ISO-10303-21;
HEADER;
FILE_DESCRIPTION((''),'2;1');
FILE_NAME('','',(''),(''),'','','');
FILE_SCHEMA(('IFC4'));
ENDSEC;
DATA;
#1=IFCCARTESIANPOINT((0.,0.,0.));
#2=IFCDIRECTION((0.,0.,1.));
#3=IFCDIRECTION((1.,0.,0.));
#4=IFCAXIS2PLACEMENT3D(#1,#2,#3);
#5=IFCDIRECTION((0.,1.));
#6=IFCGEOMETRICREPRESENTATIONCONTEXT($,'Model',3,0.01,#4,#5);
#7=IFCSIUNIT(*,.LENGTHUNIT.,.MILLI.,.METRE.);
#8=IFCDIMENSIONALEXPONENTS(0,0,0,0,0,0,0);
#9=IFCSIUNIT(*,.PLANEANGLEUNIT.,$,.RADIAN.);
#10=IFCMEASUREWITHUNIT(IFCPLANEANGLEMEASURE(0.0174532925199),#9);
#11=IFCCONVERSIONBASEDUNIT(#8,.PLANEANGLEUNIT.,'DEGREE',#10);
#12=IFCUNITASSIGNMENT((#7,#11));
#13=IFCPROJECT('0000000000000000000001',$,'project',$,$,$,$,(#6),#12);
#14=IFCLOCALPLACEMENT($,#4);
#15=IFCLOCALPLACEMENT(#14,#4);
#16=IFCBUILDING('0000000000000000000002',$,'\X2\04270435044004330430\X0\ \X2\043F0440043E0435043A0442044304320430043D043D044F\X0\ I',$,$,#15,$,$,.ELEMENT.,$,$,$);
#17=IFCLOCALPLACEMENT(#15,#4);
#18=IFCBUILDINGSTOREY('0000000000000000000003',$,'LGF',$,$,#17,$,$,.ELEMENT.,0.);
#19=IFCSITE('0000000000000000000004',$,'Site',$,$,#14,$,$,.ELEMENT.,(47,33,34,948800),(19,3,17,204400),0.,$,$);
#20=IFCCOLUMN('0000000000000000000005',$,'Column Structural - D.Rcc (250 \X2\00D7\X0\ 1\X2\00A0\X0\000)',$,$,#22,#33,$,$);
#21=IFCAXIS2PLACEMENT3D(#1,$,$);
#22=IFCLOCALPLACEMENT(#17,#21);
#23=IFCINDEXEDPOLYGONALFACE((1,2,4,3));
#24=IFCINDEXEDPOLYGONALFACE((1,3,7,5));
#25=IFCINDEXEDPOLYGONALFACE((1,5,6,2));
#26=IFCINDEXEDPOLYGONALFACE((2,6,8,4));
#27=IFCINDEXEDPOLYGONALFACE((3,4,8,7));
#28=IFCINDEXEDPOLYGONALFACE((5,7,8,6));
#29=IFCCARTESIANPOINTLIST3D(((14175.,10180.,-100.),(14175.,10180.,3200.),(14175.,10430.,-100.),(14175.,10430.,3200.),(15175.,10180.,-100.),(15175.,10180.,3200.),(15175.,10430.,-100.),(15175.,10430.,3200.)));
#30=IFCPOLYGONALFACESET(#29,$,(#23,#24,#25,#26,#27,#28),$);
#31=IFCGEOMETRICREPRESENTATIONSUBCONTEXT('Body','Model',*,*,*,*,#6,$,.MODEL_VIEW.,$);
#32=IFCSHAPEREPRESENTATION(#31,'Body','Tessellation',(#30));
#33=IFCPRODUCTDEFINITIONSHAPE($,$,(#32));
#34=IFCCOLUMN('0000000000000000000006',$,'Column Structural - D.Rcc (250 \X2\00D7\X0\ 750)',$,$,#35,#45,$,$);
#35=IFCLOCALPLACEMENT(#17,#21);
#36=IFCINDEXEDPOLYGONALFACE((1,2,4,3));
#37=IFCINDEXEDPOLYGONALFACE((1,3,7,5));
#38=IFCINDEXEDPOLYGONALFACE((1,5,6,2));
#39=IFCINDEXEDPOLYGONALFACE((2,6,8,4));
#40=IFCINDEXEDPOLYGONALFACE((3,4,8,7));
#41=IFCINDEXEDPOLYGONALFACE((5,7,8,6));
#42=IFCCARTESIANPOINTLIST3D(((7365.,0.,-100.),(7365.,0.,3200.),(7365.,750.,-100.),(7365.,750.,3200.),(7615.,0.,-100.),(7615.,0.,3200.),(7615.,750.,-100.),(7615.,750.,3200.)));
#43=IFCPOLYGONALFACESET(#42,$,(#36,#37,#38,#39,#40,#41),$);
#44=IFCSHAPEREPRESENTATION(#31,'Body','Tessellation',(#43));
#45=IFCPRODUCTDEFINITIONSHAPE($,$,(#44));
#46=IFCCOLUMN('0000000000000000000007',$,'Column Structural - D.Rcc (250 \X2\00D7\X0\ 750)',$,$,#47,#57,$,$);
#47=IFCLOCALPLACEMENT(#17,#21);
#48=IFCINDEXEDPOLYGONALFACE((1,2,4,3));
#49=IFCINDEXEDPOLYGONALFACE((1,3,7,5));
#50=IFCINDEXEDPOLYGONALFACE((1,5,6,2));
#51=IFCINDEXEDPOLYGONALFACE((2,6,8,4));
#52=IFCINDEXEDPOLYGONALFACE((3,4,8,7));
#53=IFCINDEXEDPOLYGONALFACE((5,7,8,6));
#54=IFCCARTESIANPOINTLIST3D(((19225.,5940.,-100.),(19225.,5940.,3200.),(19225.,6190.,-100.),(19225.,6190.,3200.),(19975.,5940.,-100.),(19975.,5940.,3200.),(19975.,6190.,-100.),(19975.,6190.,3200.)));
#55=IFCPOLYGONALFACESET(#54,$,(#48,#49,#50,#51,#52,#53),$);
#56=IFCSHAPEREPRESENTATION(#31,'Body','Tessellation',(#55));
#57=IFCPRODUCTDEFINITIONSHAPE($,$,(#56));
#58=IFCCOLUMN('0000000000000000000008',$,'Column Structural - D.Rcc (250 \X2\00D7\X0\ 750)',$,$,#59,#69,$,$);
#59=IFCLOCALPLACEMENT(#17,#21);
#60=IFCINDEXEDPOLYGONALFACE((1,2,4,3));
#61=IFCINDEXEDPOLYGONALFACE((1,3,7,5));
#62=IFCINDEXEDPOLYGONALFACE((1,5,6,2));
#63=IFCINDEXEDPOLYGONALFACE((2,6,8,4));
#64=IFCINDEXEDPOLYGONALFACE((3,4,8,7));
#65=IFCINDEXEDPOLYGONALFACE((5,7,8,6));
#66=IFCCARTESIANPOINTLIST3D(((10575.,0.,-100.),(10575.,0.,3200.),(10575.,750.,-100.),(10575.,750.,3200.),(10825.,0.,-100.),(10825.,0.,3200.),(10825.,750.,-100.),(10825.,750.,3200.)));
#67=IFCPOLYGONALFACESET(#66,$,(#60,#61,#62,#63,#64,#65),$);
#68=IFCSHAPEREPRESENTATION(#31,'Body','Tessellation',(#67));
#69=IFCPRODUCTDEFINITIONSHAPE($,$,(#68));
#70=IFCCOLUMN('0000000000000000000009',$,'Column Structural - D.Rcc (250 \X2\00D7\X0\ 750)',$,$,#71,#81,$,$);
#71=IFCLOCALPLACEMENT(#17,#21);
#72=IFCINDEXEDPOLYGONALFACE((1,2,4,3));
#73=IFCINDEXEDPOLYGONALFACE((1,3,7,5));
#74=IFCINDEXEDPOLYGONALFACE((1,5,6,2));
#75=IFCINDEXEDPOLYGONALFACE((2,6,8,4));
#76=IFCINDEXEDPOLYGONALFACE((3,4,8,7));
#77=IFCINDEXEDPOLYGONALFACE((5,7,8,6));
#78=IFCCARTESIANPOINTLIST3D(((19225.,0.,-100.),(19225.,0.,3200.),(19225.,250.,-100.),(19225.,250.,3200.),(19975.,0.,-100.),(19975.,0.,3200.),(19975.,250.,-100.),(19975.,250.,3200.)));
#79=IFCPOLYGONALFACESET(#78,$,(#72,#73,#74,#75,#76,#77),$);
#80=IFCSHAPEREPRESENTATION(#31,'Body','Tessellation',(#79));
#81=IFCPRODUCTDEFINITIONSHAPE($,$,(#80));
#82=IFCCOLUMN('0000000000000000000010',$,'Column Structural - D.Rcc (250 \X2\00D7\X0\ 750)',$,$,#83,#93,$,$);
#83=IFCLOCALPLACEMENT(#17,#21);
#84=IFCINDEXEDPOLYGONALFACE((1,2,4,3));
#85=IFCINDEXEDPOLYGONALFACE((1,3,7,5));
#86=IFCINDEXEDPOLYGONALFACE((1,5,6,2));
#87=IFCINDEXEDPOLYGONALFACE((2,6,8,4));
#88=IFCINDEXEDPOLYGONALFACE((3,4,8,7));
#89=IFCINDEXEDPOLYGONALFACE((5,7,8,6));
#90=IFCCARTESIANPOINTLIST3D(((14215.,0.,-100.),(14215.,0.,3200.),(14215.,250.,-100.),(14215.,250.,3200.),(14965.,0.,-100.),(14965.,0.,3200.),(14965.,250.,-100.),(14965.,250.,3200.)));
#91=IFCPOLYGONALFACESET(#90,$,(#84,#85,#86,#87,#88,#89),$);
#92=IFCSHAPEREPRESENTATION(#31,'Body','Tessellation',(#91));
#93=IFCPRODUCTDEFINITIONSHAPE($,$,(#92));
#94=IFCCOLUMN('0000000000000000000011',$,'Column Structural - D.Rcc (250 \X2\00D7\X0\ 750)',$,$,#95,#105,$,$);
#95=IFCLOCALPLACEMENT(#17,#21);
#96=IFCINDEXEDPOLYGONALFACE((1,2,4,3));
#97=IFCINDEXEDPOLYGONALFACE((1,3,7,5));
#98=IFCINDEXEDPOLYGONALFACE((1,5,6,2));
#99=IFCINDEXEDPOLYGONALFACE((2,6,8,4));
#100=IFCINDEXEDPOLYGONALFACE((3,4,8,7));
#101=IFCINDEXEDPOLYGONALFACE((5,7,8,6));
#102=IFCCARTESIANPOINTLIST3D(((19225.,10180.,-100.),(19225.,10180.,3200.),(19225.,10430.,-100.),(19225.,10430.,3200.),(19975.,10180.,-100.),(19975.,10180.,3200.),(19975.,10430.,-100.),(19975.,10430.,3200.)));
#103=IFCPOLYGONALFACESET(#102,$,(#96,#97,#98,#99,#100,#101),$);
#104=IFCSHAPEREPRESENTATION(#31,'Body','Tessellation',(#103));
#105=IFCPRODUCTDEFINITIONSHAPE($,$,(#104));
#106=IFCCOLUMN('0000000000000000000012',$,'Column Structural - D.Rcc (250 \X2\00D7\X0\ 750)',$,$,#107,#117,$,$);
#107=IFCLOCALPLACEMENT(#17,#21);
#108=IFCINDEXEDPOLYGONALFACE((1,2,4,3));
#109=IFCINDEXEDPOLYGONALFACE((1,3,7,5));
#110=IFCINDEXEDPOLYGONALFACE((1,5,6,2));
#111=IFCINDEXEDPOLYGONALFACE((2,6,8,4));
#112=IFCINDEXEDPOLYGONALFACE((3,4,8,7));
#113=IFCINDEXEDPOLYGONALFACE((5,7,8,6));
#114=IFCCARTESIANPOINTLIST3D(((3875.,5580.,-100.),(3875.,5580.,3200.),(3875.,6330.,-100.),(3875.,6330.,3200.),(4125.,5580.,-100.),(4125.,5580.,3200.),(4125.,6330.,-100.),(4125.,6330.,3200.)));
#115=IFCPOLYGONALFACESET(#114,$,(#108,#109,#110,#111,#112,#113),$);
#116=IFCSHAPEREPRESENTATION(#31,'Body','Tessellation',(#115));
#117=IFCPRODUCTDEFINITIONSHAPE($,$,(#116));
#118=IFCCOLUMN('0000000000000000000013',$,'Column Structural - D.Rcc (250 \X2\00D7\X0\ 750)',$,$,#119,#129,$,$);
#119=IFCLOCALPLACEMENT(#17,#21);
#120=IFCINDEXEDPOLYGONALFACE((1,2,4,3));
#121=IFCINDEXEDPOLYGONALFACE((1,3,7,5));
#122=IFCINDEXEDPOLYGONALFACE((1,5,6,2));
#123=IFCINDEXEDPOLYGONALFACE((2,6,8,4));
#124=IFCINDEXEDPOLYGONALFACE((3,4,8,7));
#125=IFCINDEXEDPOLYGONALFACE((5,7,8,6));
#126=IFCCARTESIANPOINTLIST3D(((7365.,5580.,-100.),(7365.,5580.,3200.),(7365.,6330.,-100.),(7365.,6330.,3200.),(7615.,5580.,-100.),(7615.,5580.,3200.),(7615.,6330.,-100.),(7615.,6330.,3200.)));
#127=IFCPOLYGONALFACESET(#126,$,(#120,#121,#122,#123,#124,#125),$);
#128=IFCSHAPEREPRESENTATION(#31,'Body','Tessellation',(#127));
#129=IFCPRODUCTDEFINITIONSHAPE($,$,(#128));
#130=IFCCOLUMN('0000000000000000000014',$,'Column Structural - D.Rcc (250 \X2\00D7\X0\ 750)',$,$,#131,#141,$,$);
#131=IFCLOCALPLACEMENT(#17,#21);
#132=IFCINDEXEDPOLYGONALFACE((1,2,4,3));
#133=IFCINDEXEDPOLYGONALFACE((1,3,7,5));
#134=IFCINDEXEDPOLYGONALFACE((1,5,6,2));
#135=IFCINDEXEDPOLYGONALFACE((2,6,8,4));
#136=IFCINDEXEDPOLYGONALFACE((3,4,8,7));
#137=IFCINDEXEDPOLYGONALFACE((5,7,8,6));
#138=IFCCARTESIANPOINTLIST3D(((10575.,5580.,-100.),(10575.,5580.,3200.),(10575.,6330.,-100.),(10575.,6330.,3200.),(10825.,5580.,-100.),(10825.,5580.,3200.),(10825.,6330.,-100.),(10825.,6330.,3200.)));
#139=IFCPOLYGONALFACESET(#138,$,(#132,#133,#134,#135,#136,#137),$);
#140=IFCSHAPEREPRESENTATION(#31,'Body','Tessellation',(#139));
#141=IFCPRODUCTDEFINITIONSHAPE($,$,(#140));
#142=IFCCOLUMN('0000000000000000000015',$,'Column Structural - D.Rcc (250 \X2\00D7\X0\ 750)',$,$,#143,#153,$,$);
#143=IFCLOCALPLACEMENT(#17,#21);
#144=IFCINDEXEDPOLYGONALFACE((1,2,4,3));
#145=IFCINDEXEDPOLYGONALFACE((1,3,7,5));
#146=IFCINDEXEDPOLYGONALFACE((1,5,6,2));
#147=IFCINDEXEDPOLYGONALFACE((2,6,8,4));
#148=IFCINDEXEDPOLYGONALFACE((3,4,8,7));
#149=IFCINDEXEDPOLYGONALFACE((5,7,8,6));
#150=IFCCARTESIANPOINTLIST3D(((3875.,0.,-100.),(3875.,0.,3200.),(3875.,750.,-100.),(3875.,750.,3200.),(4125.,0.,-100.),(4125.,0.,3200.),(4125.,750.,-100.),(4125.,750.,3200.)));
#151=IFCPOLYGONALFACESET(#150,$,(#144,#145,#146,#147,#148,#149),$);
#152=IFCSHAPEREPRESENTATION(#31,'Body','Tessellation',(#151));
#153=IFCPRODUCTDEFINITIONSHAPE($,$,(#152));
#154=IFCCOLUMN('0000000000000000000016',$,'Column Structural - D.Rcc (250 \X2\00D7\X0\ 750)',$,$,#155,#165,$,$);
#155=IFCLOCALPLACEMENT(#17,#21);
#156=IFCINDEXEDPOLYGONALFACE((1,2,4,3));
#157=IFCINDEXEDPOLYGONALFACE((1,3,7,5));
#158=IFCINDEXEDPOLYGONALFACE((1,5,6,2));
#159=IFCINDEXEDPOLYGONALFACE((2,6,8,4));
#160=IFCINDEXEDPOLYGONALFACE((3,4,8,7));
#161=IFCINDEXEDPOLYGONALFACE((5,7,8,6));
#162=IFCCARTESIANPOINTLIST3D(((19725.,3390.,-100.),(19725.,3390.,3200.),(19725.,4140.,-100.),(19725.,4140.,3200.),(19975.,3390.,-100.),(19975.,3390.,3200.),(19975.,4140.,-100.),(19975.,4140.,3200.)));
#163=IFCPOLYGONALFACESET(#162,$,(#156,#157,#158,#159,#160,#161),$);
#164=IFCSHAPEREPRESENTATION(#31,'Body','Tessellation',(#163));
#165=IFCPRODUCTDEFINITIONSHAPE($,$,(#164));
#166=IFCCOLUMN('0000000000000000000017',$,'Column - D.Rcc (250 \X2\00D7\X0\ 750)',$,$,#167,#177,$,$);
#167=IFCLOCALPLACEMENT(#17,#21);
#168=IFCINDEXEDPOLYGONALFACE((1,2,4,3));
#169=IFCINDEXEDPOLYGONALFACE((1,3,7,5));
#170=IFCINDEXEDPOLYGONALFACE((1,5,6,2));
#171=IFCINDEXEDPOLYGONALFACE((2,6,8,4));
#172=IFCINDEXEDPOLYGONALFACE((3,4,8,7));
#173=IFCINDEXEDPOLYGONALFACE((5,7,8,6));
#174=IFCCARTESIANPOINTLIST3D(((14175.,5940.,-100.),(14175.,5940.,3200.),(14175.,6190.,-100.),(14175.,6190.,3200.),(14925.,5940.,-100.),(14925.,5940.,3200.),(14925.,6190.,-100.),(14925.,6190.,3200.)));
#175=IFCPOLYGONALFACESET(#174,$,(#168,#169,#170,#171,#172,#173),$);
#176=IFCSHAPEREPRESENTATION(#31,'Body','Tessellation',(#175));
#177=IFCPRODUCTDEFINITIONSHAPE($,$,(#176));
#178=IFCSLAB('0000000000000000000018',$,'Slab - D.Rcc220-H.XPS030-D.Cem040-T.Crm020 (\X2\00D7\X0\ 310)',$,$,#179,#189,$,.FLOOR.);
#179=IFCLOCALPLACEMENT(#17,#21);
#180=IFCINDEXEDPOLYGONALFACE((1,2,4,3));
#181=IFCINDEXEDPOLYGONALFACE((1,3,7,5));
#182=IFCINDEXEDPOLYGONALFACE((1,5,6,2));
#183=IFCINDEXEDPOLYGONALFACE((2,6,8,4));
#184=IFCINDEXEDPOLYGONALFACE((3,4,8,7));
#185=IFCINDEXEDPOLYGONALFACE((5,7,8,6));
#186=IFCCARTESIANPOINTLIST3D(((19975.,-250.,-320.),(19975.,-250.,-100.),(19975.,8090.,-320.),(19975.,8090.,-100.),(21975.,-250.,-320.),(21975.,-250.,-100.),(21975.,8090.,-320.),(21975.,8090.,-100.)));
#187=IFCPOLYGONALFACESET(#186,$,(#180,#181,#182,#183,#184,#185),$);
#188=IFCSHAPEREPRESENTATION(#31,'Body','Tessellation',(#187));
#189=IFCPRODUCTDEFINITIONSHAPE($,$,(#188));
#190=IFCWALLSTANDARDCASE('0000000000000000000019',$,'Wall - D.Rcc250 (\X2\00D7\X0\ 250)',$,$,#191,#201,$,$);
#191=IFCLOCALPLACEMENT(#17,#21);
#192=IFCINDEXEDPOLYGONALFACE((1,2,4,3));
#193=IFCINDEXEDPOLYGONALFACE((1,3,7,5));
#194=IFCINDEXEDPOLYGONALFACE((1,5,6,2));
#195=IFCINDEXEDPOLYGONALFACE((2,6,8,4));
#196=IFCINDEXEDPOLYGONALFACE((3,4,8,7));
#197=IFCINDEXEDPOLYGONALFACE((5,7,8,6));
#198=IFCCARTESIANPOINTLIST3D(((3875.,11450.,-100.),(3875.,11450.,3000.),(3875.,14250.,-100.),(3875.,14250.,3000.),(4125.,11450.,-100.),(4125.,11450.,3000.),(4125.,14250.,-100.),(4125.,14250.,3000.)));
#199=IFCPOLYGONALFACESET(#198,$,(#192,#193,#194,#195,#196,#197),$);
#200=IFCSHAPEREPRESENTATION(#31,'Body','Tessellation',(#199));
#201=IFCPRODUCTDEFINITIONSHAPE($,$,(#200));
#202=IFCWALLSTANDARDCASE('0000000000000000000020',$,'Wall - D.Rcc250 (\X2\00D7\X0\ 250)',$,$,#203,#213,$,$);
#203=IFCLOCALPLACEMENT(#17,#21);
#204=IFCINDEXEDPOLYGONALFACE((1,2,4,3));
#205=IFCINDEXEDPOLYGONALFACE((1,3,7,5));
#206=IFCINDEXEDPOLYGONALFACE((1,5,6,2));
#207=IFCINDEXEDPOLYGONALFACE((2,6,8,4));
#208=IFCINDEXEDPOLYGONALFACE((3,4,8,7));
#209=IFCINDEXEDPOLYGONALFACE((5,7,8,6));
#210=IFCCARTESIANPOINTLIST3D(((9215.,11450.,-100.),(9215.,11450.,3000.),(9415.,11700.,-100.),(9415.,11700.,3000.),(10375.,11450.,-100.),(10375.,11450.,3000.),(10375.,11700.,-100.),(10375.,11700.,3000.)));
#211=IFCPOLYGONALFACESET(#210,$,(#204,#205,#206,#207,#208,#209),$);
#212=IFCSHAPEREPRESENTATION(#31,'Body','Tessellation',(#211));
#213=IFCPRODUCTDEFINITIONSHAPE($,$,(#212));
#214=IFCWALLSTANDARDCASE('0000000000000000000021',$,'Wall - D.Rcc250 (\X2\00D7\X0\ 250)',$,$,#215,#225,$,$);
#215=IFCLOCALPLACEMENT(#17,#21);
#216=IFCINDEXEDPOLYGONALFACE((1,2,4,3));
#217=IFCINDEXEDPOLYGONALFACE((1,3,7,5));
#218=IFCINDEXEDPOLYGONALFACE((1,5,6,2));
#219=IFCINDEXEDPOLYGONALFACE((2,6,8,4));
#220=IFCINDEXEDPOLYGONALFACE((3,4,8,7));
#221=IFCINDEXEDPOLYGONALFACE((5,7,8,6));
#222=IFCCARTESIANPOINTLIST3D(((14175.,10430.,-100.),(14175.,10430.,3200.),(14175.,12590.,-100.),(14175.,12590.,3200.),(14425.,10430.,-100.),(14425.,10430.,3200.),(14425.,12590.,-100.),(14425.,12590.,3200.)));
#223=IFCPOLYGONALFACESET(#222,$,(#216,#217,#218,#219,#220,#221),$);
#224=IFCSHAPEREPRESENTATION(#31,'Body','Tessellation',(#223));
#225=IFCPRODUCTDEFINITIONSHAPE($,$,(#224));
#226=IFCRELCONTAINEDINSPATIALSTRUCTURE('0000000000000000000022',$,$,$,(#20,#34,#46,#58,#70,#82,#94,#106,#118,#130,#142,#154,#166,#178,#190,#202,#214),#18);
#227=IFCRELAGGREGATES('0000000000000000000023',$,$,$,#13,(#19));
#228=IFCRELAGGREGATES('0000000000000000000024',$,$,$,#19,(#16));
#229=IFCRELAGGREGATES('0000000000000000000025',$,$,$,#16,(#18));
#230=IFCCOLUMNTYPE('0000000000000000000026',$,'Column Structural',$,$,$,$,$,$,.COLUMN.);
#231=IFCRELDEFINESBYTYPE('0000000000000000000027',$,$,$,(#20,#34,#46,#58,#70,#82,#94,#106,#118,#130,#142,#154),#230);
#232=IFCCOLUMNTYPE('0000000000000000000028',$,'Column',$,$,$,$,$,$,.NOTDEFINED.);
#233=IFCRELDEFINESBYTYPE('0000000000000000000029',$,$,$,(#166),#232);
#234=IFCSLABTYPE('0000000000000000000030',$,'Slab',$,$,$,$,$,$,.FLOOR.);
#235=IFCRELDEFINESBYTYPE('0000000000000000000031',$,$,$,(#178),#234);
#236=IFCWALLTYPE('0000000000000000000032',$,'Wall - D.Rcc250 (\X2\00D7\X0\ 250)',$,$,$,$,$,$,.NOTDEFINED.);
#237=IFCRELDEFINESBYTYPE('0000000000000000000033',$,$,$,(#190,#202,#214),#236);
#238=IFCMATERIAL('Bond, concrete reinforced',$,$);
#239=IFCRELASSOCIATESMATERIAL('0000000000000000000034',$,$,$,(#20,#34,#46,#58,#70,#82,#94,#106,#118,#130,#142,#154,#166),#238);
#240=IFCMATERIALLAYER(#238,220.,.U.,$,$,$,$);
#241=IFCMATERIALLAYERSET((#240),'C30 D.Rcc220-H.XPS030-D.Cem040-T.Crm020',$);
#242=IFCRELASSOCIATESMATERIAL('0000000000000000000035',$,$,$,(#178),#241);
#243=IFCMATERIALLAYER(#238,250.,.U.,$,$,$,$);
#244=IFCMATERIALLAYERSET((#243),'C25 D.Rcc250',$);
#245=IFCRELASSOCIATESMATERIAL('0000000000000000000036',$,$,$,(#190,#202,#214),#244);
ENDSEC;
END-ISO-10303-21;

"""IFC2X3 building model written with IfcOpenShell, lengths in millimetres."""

from ifc_helpers import new_model, entity, si_unit, converted_unit, direction, frame, origin_with_axes, origin_2d_with_axis, place, context, subcontext, project, spatial, polyline, rectangle, outline, extrude, material, layer, layer_set, layer_usage, type_object, element, save


model = new_model("IFC2X3")

# Units and contexts
model_context = context("Model", 3, precision=0.01, world=origin_with_axes(), true_north=direction((0.0, 1.0)))
body_context = subcontext(model_context, "Body", "Model", "MODEL_VIEW")
ifc_project = project(units=[si_unit("LENGTHUNIT", "METRE", prefix="MILLI"), converted_unit("PLANEANGLEUNIT", "DEGREE", entity("IfcPlaneAngleMeasure", 0.0174532925199), si_unit("PLANEANGLEUNIT", "RADIAN"), dimensions=[0, 0, 0, 0, 0, 0, 0])], contexts=[model_context])

# Site, building, storey
site_placement = place(None, origin_with_axes())
site = spatial("IfcSite", under=ifc_project, at=site_placement, Name="Site", CompositionType="ELEMENT", RefLatitude=(47, 33, 34, 948800), RefLongitude=(19, 3, 17, 204400), RefElevation=0.0)
building_placement = place(site_placement, origin_with_axes())
building = spatial("IfcBuilding", under=site, at=building_placement, Name="Черга проектування I", CompositionType="ELEMENT")
storey_placement = place(building_placement, origin_with_axes())
storey = spatial("IfcBuildingStorey", under=building, at=storey_placement, Name="LGF", CompositionType="ELEMENT", Elevation=0.0)

# Columns
ifc_material = material(Name="Bond, concrete reinforced")
column_type_1 = type_object("IfcColumnType", Name="Column Structural", PredefinedType="COLUMN")
column_1_placement = place(storey_placement, frame((14675.0, 10305.0, -100.0), z_axis=(0.0, 0.0, 1.0), x_axis=(-1.0, 0.0, 0.0)))
element("IfcColumn", 1, at=column_1_placement, inside=storey, type_object=column_type_1, material=ifc_material, Name="Column Structural - D.Rcc (250 × 1 000)", context=body_context, shape_type="SweptSolid", body=[
    extrude(rectangle(XDim=1000.0, YDim=250.0, at=origin_2d_with_axis()), origin_with_axes(), (0.0, 0.0, 1.0), 3300.0),
])
for number, where, z_axis, x_axis, name in (
    (2, (7490.0, 375.0, -100.0), (0.0, 0.0, 1.0), (0.0, 1.0, 0.0), "Column Structural - D.Rcc (250 × 750)"),
    (3, (19600.0, 6065.0, -100.0), (0.0, 0.0, 1.0), (-1.0, 0.0, 0.0), "Column Structural - D.Rcc (250 × 750)"),
    (4, (10700.0, 375.0, -100.0), (0.0, 0.0, 1.0), (0.0, 1.0, 0.0), "Column Structural - D.Rcc (250 × 750)"),
    (5, (19600.0, 125.0, -100.0), (0.0, 0.0, 1.0), (-1.0, 0.0, 0.0), "Column Structural - D.Rcc (250 × 750)"),
    (6, (14590.0, 125.0, -100.0), (0.0, 0.0, 1.0), (1.0, 0.0, 0.0), "Column Structural - D.Rcc (250 × 750)"),
    (7, (19600.0, 10305.0, -100.0), (0.0, 0.0, 1.0), (-1.0, 0.0, 0.0), "Column Structural - D.Rcc (250 × 750)"),
    (8, (4000.0, 5955.0, -100.0), (0.0, 0.0, 1.0), (0.0, 1.0, 0.0), "Column Structural - D.Rcc (250 × 750)"),
    (9, (7490.0, 5955.0, -100.0), (0.0, 0.0, 1.0), (0.0, 1.0, 0.0), "Column Structural - D.Rcc (250 × 750)"),
    (10, (10700.0, 5955.0, -100.0), (0.0, 0.0, 1.0), (0.0, 1.0, 0.0), "Column Structural - D.Rcc (250 × 750)"),
    (11, (4000.0, 375.0, -100.0), (0.0, 0.0, 1.0), (0.0, 1.0, 0.0), "Column Structural - D.Rcc (250 × 750)"),
    (12, (19850.0, 3765.0, -100.0), (0.0, 0.0, 1.0), (0.0, 1.0, 0.0), "Column Structural - D.Rcc (250 × 750)"),
):
    element("IfcColumn", number, at=place(storey_placement, frame(where, z_axis=z_axis, x_axis=x_axis)), inside=storey, type_object=column_type_1, material=ifc_material, Name=name, context=body_context, shape_type="SweptSolid", body=[
        extrude(rectangle(XDim=750.0, YDim=250.0, at=origin_2d_with_axis()), origin_with_axes(), (0.0, 0.0, 1.0), 3300.0),
    ])
column_type_2 = type_object("IfcColumnType", Name="Column", PredefinedType="NOTDEFINED")
column_2_placement = place(storey_placement, frame((14550.0, 6065.0, -100.0), z_axis=(0.0, 0.0, 1.0), x_axis=(-1.0, 0.0, 0.0)))
element("IfcColumn", 13, at=column_2_placement, inside=storey, type_object=column_type_2, material=ifc_material, Name="Column - D.Rcc (250 × 750)", context=body_context, shape_type="SweptSolid", body=[
    extrude(rectangle(XDim=750.0, YDim=250.0, at=origin_2d_with_axis()), origin_with_axes(), (0.0, 0.0, 1.0), 3300.0),
])

# Slab
ifc_layer_1 = layer(ifc_material, 220.0, ventilated="UNKNOWN")
ifc_layer_set_1 = layer_set([ifc_layer_1], Name="C30 D.Rcc220-H.XPS030-D.Cem040-T.Crm020")
ifc_layer_usage_1 = layer_usage(ifc_layer_set_1, "AXIS3", "NEGATIVE", 220.0)
slab_type = type_object("IfcSlabType", Name="Slab", PredefinedType="FLOOR")
slab_placement = place(storey_placement, frame((21975.0, 8090.0, -100.0), z_axis=(0.0, 0.0, 1.0), x_axis=(1.0, 0.0, 0.0)))
element("IfcSlab", 14, at=slab_placement, inside=storey, type_object=slab_type, material=ifc_layer_usage_1, Name="Slab - D.Rcc220-H.XPS030-D.Cem040-T.Crm020 (× 310)", PredefinedType="FLOOR", context=body_context, shape_type="SweptSolid", body=[
    extrude(outline(polyline([(0.0, 0.0), (-2000.0, 0.0), (-2000.0, -8340.0), (0.0, -8340.0), (0.0, 0.0)])), frame((0.0, 0.0, -220.0), z_axis=(0.0, 0.0, 1.0), x_axis=(1.0, 0.0, 0.0)), (0.0, 0.0, 1.0), 220.0),
])

# Walls
ifc_layer_2 = layer(ifc_material, 250.0, ventilated="UNKNOWN")
ifc_layer_set_2 = layer_set([ifc_layer_2], Name="C25 D.Rcc250")
ifc_layer_usage_2 = layer_usage(ifc_layer_set_2, "AXIS2", "POSITIVE", -250.0)
wall_type_1 = type_object("IfcWallType", Name="Wall - D.Rcc250 (× 250)", PredefinedType="NOTDEFINED")
wall_1_placement = place(storey_placement, frame((4125.0, 14250.0, -100.0), z_axis=(0.0, 0.0, 1.0), x_axis=(0.0, -1.0, 0.0)))
element("IfcWallStandardCase", 15, at=wall_1_placement, inside=storey, type_object=wall_type_1, material=ifc_layer_usage_2, Name="Wall - D.Rcc250 (× 250)", context=body_context, shape_type="SweptSolid", body=[
    extrude(outline(polyline([(0.0, -250.0), (2800.0, -250.0), (2800.0, 0.0), (0.0, 0.0), (0.0, -250.0)])), origin_with_axes(), (0.0, 0.0, 1.0), 3100.0),
])
ifc_layer_usage_3 = layer_usage(ifc_layer_set_2, "AXIS2", "NEGATIVE", 250.0)
wall_2_placement = place(storey_placement, frame((9415.0, 11450.0, -100.0), z_axis=(0.0, 0.0, 1.0), x_axis=(1.0, 0.0, 0.0)))
element("IfcWallStandardCase", 16, at=wall_2_placement, inside=storey, type_object=wall_type_1, material=ifc_layer_usage_3, Name="Wall - D.Rcc250 (× 250)", context=body_context, shape_type="SweptSolid", body=[
    extrude(outline(polyline([(-200.0, 0.0), (960.0, 0.0), (960.0, 250.0), (0.0, 250.0), (-200.0, 0.0)])), origin_with_axes(), (0.0, 0.0, 1.0), 3100.0),
])

# Wall
ifc_layer_usage_4 = layer_usage(ifc_layer_set_2, "AXIS2", "POSITIVE", -250.0)
wall_3_placement = place(storey_placement, frame((14175.0, 10430.0, -100.0), z_axis=(0.0, 0.0, 1.0), x_axis=(0.0, 1.0, 0.0)))
element("IfcWallStandardCase", 17, at=wall_3_placement, inside=storey, type_object=wall_type_1, material=ifc_layer_usage_4, Name="Wall - D.Rcc250 (× 250)", context=body_context, shape_type="SweptSolid", body=[
    extrude(outline(polyline([(0.0, -250.0), (2160.0, -250.0), (2160.0, 0.0), (0.0, 0.0), (0.0, -250.0)])), origin_with_axes(), (0.0, 0.0, 1.0), 3300.0),
])

save(model, "model.ifc")
